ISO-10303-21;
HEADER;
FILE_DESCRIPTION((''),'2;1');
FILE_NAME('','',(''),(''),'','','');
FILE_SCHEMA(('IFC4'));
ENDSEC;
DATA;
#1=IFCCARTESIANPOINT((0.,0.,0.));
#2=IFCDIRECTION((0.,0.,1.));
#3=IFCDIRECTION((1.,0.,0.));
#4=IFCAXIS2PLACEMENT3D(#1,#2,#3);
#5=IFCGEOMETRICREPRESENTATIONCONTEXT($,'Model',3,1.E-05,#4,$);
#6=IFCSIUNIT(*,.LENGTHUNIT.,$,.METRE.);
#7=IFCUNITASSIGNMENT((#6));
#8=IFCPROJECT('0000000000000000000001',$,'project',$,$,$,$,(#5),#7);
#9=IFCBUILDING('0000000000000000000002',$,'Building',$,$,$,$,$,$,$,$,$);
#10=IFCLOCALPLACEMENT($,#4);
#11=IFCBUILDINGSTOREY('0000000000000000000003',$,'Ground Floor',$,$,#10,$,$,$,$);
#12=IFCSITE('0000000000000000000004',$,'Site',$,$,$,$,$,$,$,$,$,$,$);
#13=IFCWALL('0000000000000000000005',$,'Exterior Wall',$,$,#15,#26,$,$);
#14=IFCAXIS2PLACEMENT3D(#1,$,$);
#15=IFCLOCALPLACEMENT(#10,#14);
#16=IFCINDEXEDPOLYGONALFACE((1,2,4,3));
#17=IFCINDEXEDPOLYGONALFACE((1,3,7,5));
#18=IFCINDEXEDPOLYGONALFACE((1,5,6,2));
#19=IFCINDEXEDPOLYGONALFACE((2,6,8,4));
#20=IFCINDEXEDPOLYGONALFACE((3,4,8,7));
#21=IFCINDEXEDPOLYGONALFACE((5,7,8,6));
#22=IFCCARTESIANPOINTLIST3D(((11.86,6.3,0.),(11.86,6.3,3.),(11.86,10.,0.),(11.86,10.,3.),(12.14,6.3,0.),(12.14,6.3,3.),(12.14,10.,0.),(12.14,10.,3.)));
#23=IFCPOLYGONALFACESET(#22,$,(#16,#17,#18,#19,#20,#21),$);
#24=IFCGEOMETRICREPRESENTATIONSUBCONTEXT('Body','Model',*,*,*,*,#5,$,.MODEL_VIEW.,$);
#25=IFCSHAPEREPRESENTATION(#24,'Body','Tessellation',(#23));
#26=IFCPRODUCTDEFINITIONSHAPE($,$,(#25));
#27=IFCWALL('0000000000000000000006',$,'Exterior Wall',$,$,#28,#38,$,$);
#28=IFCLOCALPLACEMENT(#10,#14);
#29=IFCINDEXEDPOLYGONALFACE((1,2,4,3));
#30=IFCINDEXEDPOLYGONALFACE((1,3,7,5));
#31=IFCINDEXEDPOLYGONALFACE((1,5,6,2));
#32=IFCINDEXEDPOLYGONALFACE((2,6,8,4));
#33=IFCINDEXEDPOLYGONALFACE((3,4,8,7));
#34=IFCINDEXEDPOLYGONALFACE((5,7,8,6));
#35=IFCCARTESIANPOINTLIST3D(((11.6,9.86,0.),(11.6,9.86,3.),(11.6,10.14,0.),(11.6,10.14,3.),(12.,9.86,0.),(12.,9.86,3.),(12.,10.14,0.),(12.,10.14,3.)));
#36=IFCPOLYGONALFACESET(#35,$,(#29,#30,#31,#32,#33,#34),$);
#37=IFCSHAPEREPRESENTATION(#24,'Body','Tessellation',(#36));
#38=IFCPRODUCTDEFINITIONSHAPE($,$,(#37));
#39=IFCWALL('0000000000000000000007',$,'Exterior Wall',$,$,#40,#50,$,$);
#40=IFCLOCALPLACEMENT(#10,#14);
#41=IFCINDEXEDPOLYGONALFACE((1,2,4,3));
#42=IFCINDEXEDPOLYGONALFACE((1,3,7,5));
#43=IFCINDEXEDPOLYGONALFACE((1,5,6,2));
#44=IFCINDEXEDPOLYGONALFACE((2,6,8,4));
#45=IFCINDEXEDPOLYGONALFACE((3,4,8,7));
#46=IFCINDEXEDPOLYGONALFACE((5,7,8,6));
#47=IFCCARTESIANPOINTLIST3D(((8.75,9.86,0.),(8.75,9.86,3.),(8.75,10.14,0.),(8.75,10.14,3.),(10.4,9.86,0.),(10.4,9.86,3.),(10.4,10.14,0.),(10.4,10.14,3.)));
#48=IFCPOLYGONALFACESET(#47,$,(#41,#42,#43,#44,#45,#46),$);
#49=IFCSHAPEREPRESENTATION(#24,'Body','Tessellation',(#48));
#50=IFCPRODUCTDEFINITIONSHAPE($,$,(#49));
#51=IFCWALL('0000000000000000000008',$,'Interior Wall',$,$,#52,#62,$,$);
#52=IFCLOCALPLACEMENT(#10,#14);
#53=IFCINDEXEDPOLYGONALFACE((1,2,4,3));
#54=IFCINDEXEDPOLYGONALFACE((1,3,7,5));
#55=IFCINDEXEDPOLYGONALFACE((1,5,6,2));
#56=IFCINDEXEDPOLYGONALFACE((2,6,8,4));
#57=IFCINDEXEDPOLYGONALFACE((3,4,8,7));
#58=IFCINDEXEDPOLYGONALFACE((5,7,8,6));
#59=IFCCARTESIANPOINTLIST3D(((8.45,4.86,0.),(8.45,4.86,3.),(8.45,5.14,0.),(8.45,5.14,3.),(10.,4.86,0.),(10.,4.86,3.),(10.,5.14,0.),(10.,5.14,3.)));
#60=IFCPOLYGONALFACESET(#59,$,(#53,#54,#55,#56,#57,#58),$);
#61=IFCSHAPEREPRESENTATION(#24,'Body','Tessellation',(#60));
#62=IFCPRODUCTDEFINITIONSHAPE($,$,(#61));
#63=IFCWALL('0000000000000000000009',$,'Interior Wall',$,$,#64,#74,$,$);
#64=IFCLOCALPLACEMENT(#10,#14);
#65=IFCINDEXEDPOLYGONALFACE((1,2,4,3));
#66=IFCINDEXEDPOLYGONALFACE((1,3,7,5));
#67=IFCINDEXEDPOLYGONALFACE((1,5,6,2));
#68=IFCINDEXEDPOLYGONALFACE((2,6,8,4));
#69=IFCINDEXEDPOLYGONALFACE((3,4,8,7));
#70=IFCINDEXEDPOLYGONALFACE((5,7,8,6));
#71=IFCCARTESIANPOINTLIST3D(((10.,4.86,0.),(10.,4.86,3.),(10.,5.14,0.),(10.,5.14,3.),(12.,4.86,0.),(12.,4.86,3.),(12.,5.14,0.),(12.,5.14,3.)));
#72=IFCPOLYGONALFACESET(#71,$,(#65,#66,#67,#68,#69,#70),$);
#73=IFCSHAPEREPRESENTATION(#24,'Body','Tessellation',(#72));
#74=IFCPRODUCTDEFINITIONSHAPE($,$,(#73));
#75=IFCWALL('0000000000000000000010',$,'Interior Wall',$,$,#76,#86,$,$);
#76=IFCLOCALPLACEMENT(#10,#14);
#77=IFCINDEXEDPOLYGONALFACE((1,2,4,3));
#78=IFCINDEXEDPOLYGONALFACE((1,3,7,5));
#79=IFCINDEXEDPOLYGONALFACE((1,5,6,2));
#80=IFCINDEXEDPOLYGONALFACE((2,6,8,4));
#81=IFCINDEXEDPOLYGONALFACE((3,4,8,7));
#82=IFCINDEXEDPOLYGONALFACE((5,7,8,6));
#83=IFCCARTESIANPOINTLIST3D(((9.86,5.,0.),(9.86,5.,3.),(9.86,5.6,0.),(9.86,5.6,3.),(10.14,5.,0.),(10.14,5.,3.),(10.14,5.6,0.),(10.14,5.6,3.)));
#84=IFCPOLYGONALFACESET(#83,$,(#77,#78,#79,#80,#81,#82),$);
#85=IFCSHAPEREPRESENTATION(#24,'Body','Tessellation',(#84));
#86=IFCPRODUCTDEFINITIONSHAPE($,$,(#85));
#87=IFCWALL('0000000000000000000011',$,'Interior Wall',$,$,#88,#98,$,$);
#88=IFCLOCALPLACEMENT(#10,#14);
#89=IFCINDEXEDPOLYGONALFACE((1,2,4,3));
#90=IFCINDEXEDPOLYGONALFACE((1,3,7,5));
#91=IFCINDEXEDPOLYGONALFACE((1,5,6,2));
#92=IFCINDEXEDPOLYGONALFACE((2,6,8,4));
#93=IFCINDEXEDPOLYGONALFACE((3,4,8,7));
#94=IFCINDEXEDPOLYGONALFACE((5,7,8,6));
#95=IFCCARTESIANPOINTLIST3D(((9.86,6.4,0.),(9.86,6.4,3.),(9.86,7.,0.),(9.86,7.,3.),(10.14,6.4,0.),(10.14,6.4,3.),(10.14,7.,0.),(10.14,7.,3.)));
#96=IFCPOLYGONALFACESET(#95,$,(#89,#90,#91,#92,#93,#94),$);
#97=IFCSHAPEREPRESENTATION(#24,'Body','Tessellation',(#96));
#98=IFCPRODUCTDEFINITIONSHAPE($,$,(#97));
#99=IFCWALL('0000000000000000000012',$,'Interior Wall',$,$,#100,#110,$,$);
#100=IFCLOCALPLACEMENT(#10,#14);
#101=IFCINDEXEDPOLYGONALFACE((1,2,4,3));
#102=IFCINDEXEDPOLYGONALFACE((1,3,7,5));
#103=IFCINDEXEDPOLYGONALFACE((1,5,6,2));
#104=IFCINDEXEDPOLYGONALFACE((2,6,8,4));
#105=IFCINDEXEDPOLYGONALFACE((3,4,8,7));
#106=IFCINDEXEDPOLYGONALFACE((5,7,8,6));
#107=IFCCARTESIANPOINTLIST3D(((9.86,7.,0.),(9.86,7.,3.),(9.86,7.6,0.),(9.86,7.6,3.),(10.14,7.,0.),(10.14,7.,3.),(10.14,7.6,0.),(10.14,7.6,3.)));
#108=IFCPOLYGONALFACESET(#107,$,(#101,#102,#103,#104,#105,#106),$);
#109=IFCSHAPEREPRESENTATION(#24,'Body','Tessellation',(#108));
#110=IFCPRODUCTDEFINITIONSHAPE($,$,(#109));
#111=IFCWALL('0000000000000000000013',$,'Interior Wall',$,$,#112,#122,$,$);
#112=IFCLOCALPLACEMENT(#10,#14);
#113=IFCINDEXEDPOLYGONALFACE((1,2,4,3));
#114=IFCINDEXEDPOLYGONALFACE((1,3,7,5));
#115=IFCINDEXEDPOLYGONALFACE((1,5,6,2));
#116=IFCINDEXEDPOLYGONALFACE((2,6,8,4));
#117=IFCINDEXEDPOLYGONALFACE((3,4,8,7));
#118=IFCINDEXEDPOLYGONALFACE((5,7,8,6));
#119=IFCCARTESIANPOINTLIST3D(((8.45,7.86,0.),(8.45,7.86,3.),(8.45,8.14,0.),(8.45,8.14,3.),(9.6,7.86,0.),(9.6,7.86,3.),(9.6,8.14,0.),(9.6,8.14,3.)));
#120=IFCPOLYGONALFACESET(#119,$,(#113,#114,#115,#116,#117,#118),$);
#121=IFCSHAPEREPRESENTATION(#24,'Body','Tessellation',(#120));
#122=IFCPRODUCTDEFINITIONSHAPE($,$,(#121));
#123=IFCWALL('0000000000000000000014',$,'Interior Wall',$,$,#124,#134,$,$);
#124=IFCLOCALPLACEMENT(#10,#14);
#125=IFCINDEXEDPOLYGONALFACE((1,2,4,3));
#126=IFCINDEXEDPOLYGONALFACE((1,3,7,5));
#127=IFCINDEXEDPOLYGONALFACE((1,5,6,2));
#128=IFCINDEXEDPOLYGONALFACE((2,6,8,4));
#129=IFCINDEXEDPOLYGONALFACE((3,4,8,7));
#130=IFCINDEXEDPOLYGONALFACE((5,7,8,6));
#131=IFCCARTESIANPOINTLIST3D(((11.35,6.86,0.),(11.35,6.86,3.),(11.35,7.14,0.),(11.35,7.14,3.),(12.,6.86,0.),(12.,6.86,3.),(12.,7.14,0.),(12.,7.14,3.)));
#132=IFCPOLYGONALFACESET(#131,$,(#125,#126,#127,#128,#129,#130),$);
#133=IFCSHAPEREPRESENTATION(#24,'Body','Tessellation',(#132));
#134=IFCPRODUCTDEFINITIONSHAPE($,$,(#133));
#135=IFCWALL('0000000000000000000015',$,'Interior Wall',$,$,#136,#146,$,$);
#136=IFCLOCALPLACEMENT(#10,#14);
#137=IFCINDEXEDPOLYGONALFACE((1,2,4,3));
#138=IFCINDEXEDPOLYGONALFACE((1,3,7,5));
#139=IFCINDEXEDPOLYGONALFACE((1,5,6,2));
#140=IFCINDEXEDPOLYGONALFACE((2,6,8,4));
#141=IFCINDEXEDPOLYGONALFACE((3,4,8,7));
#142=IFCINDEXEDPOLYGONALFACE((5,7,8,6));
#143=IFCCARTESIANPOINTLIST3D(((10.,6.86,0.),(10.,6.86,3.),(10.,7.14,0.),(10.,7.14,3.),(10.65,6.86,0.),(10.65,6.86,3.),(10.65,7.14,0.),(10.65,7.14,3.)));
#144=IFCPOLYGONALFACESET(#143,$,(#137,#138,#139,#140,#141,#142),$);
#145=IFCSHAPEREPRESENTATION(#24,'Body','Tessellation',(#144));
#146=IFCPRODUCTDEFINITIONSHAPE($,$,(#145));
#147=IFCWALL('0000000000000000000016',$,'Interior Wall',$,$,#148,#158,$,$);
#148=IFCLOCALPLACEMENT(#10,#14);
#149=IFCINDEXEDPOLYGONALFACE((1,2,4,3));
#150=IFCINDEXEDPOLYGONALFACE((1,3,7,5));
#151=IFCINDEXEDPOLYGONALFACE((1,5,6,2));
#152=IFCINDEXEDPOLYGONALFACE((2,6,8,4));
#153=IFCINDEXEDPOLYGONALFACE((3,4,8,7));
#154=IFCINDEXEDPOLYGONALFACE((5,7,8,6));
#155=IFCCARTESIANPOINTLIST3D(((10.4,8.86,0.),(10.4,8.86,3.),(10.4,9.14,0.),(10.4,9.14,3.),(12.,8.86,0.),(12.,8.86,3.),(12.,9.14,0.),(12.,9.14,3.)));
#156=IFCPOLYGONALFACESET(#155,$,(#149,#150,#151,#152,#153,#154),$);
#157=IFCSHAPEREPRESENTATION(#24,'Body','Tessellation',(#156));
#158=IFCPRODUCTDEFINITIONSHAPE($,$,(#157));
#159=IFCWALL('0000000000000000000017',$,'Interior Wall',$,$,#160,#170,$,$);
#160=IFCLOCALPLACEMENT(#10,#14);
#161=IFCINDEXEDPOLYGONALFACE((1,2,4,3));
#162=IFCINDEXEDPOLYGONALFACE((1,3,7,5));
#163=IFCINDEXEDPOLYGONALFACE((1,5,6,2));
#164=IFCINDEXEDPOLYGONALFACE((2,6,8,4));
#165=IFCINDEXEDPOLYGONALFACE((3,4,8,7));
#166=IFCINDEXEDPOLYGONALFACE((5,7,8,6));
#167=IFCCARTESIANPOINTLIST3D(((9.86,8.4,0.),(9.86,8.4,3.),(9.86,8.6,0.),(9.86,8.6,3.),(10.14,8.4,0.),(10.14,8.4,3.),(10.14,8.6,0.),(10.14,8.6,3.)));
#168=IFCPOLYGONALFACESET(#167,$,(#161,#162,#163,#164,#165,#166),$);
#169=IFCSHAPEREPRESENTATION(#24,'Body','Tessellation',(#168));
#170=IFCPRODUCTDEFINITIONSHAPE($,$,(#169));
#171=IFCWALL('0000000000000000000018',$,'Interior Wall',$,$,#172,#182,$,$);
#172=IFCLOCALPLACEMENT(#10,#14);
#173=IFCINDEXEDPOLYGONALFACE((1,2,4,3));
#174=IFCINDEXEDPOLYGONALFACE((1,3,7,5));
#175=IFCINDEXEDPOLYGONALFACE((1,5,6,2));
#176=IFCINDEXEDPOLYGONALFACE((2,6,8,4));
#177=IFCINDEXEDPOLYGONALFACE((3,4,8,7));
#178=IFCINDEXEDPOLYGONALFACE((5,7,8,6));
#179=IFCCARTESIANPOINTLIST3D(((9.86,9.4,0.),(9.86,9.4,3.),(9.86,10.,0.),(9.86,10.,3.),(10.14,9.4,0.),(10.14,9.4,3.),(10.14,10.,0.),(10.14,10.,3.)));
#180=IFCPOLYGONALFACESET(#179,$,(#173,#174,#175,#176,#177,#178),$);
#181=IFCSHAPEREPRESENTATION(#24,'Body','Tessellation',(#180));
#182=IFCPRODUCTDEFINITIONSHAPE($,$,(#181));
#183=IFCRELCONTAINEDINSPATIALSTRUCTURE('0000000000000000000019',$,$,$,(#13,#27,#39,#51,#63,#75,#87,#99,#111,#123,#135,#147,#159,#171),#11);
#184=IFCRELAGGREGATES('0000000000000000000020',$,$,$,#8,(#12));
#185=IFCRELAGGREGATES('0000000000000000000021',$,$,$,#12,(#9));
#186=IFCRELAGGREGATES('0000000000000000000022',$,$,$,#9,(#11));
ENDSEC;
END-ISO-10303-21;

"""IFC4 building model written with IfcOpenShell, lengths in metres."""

from ifc_helpers import new_model, si_unit, frame, origin_with_axes, place, context, subcontext, project, spatial, indexed_curve, outline, extrude, element, save


model = new_model("IFC4")

# Units and contexts
model_context = context("Model", 3, precision=1e-05, world=origin_with_axes())
body_context = subcontext(model_context, "Body", "Model", "MODEL_VIEW")
ifc_project = project(units=[si_unit("LENGTHUNIT", "METRE")], contexts=[model_context])

# Site, building, storey
site = spatial("IfcSite", under=ifc_project, Name="Site")
building = spatial("IfcBuilding", under=site, Name="Building")
storey_placement = place(None, origin_with_axes())
storey = spatial("IfcBuildingStorey", under=building, at=storey_placement, Name="Ground Floor")

# Walls
wall_1_placement = place(storey_placement, frame((12.0, 6.3, 0.0), z_axis=(0.0, 0.0, 1.0), x_axis=(0.0, 1.0, 0.0)))
element("IfcWall", 1, at=wall_1_placement, inside=storey, Name="Exterior Wall", context=body_context, shape_type="SweptSolid", body=[
    extrude(outline(indexed_curve([(0.0, 0.0), (0.0, 0.28), (3.7, 0.28), (3.7, 0.0), (0.0, 0.0)], self_intersect=False)), frame((0.0, -0.14, 0.0), z_axis=(0.0, 0.0, 1.0), x_axis=(1.0, 0.0, 0.0)), (0.0, 0.0, 1.0), 3.0),
])
wall_2_placement = place(storey_placement, frame((12.0, 10.0, 0.0), z_axis=(0.0, 0.0, 1.0), x_axis=(-1.0, 0.0, 0.0)))
element("IfcWall", 2, at=wall_2_placement, inside=storey, Name="Exterior Wall", context=body_context, shape_type="SweptSolid", body=[
    extrude(outline(indexed_curve([(0.0, 0.0), (0.0, 0.28), (0.4, 0.28), (0.4, 0.0), (0.0, 0.0)], self_intersect=False)), frame((0.0, -0.14, 0.0), z_axis=(0.0, 0.0, 1.0), x_axis=(1.0, 0.0, 0.0)), (0.0, 0.0, 1.0), 3.0),
])
wall_3_placement = place(storey_placement, frame((10.4, 10.0, 0.0), z_axis=(0.0, 0.0, 1.0), x_axis=(-1.0, 0.0, 0.0)))
element("IfcWall", 3, at=wall_3_placement, inside=storey, Name="Exterior Wall", context=body_context, shape_type="SweptSolid", body=[
    extrude(outline(indexed_curve([(0.0, 0.0), (0.0, 0.28), (1.65, 0.28), (1.65, 0.0), (0.0, 0.0)], self_intersect=False)), frame((0.0, -0.14, 0.0), z_axis=(0.0, 0.0, 1.0), x_axis=(1.0, 0.0, 0.0)), (0.0, 0.0, 1.0), 3.0),
])
wall_4_placement = place(storey_placement, frame((10.0, 5.0, 0.0), z_axis=(0.0, 0.0, 1.0), x_axis=(-1.0, 0.0, 0.0)))
element("IfcWall", 4, at=wall_4_placement, inside=storey, Name="Interior Wall", context=body_context, shape_type="SweptSolid", body=[
    extrude(outline(indexed_curve([(0.0, 0.0), (0.0, 0.28), (1.55, 0.28), (1.55, 0.0), (0.0, 0.0)], self_intersect=False)), frame((0.0, -0.14, 0.0), z_axis=(0.0, 0.0, 1.0), x_axis=(1.0, 0.0, 0.0)), (0.0, 0.0, 1.0), 3.0),
])
wall_5_placement = place(storey_placement, frame((12.0, 5.0, 0.0), z_axis=(0.0, 0.0, 1.0), x_axis=(-1.0, 0.0, 0.0)))
element("IfcWall", 5, at=wall_5_placement, inside=storey, Name="Interior Wall", context=body_context, shape_type="SweptSolid", body=[
    extrude(outline(indexed_curve([(0.0, 0.0), (0.0, 0.28), (2.0, 0.28), (2.0, 0.0), (0.0, 0.0)], self_intersect=False)), frame((0.0, -0.14, 0.0), z_axis=(0.0, 0.0, 1.0), x_axis=(1.0, 0.0, 0.0)), (0.0, 0.0, 1.0), 3.0),
])
for number, where, z_axis, x_axis, name in (
    (6, (10.0, 5.0, 0.0), (0.0, 0.0, 1.0), (0.0, 1.0, 0.0), "Interior Wall"),
    (7, (10.0, 6.4, 0.0), (0.0, 0.0, 1.0), (0.0, 1.0, 0.0), "Interior Wall"),
    (8, (10.0, 7.0, 0.0), (0.0, 0.0, 1.0), (0.0, 1.0, 0.0), "Interior Wall"),
):
    element("IfcWall", number, at=place(storey_placement, frame(where, z_axis=z_axis, x_axis=x_axis)), inside=storey, Name=name, context=body_context, shape_type="SweptSolid", body=[
        extrude(outline(indexed_curve([(0.0, 0.0), (0.0, 0.28), (0.6, 0.28), (0.6, 0.0), (0.0, 0.0)], self_intersect=False)), frame((0.0, -0.14, 0.0), z_axis=(0.0, 0.0, 1.0), x_axis=(1.0, 0.0, 0.0)), (0.0, 0.0, 1.0), 3.0),
    ])
wall_6_placement = place(storey_placement, frame((9.6, 8.0, 0.0), z_axis=(0.0, 0.0, 1.0), x_axis=(-1.0, 0.0, 0.0)))
element("IfcWall", 9, at=wall_6_placement, inside=storey, Name="Interior Wall", context=body_context, shape_type="SweptSolid", body=[
    extrude(outline(indexed_curve([(0.0, 0.0), (0.0, 0.28), (1.15, 0.28), (1.15, 0.0), (0.0, 0.0)], self_intersect=False)), frame((0.0, -0.14, 0.0), z_axis=(0.0, 0.0, 1.0), x_axis=(1.0, 0.0, 0.0)), (0.0, 0.0, 1.0), 3.0),
])
for number, where, z_axis, x_axis, name in (
    (10, (12.0, 7.0, 0.0), (0.0, 0.0, 1.0), (-1.0, 0.0, 0.0), "Interior Wall"),
    (11, (10.65, 7.0, 0.0), (0.0, 0.0, 1.0), (-1.0, 0.0, 0.0), "Interior Wall"),
):
    element("IfcWall", number, at=place(storey_placement, frame(where, z_axis=z_axis, x_axis=x_axis)), inside=storey, Name=name, context=body_context, shape_type="SweptSolid", body=[
        extrude(outline(indexed_curve([(0.0, 0.0), (0.0, 0.28), (0.65, 0.28), (0.65, 0.0), (0.0, 0.0)], self_intersect=False)), frame((0.0, -0.14, 0.0), z_axis=(0.0, 0.0, 1.0), x_axis=(1.0, 0.0, 0.0)), (0.0, 0.0, 1.0), 3.0),
    ])
wall_7_placement = place(storey_placement, frame((12.0, 9.0, 0.0), z_axis=(0.0, 0.0, 1.0), x_axis=(-1.0, 0.0, 0.0)))
element("IfcWall", 12, at=wall_7_placement, inside=storey, Name="Interior Wall", context=body_context, shape_type="SweptSolid", body=[
    extrude(outline(indexed_curve([(0.0, 0.0), (0.0, 0.28), (1.6, 0.28), (1.6, 0.0), (0.0, 0.0)], self_intersect=False)), frame((0.0, -0.14, 0.0), z_axis=(0.0, 0.0, 1.0), x_axis=(1.0, 0.0, 0.0)), (0.0, 0.0, 1.0), 3.0),
])
wall_8_placement = place(storey_placement, frame((10.0, 8.6, 0.0), z_axis=(0.0, 0.0, 1.0), x_axis=(0.0, -1.0, 0.0)))
element("IfcWall", 13, at=wall_8_placement, inside=storey, Name="Interior Wall", context=body_context, shape_type="SweptSolid", body=[
    extrude(outline(indexed_curve([(0.0, 0.0), (0.0, 0.28), (0.2, 0.28), (0.2, 0.0), (0.0, 0.0)], self_intersect=False)), frame((0.0, -0.14, 0.0), z_axis=(0.0, 0.0, 1.0), x_axis=(1.0, 0.0, 0.0)), (0.0, 0.0, 1.0), 3.0),
])
wall_9_placement = place(storey_placement, frame((10.0, 9.4, 0.0), z_axis=(0.0, 0.0, 1.0), x_axis=(0.0, 1.0, 0.0)))
element("IfcWall", 14, at=wall_9_placement, inside=storey, Name="Interior Wall", context=body_context, shape_type="SweptSolid", body=[
    extrude(outline(indexed_curve([(0.0, 0.0), (0.0, 0.28), (0.6, 0.28), (0.6, 0.0), (0.0, 0.0)], self_intersect=False)), frame((0.0, -0.14, 0.0), z_axis=(0.0, 0.0, 1.0), x_axis=(1.0, 0.0, 0.0)), (0.0, 0.0, 1.0), 3.0),
])

save(model, "model.ifc")
